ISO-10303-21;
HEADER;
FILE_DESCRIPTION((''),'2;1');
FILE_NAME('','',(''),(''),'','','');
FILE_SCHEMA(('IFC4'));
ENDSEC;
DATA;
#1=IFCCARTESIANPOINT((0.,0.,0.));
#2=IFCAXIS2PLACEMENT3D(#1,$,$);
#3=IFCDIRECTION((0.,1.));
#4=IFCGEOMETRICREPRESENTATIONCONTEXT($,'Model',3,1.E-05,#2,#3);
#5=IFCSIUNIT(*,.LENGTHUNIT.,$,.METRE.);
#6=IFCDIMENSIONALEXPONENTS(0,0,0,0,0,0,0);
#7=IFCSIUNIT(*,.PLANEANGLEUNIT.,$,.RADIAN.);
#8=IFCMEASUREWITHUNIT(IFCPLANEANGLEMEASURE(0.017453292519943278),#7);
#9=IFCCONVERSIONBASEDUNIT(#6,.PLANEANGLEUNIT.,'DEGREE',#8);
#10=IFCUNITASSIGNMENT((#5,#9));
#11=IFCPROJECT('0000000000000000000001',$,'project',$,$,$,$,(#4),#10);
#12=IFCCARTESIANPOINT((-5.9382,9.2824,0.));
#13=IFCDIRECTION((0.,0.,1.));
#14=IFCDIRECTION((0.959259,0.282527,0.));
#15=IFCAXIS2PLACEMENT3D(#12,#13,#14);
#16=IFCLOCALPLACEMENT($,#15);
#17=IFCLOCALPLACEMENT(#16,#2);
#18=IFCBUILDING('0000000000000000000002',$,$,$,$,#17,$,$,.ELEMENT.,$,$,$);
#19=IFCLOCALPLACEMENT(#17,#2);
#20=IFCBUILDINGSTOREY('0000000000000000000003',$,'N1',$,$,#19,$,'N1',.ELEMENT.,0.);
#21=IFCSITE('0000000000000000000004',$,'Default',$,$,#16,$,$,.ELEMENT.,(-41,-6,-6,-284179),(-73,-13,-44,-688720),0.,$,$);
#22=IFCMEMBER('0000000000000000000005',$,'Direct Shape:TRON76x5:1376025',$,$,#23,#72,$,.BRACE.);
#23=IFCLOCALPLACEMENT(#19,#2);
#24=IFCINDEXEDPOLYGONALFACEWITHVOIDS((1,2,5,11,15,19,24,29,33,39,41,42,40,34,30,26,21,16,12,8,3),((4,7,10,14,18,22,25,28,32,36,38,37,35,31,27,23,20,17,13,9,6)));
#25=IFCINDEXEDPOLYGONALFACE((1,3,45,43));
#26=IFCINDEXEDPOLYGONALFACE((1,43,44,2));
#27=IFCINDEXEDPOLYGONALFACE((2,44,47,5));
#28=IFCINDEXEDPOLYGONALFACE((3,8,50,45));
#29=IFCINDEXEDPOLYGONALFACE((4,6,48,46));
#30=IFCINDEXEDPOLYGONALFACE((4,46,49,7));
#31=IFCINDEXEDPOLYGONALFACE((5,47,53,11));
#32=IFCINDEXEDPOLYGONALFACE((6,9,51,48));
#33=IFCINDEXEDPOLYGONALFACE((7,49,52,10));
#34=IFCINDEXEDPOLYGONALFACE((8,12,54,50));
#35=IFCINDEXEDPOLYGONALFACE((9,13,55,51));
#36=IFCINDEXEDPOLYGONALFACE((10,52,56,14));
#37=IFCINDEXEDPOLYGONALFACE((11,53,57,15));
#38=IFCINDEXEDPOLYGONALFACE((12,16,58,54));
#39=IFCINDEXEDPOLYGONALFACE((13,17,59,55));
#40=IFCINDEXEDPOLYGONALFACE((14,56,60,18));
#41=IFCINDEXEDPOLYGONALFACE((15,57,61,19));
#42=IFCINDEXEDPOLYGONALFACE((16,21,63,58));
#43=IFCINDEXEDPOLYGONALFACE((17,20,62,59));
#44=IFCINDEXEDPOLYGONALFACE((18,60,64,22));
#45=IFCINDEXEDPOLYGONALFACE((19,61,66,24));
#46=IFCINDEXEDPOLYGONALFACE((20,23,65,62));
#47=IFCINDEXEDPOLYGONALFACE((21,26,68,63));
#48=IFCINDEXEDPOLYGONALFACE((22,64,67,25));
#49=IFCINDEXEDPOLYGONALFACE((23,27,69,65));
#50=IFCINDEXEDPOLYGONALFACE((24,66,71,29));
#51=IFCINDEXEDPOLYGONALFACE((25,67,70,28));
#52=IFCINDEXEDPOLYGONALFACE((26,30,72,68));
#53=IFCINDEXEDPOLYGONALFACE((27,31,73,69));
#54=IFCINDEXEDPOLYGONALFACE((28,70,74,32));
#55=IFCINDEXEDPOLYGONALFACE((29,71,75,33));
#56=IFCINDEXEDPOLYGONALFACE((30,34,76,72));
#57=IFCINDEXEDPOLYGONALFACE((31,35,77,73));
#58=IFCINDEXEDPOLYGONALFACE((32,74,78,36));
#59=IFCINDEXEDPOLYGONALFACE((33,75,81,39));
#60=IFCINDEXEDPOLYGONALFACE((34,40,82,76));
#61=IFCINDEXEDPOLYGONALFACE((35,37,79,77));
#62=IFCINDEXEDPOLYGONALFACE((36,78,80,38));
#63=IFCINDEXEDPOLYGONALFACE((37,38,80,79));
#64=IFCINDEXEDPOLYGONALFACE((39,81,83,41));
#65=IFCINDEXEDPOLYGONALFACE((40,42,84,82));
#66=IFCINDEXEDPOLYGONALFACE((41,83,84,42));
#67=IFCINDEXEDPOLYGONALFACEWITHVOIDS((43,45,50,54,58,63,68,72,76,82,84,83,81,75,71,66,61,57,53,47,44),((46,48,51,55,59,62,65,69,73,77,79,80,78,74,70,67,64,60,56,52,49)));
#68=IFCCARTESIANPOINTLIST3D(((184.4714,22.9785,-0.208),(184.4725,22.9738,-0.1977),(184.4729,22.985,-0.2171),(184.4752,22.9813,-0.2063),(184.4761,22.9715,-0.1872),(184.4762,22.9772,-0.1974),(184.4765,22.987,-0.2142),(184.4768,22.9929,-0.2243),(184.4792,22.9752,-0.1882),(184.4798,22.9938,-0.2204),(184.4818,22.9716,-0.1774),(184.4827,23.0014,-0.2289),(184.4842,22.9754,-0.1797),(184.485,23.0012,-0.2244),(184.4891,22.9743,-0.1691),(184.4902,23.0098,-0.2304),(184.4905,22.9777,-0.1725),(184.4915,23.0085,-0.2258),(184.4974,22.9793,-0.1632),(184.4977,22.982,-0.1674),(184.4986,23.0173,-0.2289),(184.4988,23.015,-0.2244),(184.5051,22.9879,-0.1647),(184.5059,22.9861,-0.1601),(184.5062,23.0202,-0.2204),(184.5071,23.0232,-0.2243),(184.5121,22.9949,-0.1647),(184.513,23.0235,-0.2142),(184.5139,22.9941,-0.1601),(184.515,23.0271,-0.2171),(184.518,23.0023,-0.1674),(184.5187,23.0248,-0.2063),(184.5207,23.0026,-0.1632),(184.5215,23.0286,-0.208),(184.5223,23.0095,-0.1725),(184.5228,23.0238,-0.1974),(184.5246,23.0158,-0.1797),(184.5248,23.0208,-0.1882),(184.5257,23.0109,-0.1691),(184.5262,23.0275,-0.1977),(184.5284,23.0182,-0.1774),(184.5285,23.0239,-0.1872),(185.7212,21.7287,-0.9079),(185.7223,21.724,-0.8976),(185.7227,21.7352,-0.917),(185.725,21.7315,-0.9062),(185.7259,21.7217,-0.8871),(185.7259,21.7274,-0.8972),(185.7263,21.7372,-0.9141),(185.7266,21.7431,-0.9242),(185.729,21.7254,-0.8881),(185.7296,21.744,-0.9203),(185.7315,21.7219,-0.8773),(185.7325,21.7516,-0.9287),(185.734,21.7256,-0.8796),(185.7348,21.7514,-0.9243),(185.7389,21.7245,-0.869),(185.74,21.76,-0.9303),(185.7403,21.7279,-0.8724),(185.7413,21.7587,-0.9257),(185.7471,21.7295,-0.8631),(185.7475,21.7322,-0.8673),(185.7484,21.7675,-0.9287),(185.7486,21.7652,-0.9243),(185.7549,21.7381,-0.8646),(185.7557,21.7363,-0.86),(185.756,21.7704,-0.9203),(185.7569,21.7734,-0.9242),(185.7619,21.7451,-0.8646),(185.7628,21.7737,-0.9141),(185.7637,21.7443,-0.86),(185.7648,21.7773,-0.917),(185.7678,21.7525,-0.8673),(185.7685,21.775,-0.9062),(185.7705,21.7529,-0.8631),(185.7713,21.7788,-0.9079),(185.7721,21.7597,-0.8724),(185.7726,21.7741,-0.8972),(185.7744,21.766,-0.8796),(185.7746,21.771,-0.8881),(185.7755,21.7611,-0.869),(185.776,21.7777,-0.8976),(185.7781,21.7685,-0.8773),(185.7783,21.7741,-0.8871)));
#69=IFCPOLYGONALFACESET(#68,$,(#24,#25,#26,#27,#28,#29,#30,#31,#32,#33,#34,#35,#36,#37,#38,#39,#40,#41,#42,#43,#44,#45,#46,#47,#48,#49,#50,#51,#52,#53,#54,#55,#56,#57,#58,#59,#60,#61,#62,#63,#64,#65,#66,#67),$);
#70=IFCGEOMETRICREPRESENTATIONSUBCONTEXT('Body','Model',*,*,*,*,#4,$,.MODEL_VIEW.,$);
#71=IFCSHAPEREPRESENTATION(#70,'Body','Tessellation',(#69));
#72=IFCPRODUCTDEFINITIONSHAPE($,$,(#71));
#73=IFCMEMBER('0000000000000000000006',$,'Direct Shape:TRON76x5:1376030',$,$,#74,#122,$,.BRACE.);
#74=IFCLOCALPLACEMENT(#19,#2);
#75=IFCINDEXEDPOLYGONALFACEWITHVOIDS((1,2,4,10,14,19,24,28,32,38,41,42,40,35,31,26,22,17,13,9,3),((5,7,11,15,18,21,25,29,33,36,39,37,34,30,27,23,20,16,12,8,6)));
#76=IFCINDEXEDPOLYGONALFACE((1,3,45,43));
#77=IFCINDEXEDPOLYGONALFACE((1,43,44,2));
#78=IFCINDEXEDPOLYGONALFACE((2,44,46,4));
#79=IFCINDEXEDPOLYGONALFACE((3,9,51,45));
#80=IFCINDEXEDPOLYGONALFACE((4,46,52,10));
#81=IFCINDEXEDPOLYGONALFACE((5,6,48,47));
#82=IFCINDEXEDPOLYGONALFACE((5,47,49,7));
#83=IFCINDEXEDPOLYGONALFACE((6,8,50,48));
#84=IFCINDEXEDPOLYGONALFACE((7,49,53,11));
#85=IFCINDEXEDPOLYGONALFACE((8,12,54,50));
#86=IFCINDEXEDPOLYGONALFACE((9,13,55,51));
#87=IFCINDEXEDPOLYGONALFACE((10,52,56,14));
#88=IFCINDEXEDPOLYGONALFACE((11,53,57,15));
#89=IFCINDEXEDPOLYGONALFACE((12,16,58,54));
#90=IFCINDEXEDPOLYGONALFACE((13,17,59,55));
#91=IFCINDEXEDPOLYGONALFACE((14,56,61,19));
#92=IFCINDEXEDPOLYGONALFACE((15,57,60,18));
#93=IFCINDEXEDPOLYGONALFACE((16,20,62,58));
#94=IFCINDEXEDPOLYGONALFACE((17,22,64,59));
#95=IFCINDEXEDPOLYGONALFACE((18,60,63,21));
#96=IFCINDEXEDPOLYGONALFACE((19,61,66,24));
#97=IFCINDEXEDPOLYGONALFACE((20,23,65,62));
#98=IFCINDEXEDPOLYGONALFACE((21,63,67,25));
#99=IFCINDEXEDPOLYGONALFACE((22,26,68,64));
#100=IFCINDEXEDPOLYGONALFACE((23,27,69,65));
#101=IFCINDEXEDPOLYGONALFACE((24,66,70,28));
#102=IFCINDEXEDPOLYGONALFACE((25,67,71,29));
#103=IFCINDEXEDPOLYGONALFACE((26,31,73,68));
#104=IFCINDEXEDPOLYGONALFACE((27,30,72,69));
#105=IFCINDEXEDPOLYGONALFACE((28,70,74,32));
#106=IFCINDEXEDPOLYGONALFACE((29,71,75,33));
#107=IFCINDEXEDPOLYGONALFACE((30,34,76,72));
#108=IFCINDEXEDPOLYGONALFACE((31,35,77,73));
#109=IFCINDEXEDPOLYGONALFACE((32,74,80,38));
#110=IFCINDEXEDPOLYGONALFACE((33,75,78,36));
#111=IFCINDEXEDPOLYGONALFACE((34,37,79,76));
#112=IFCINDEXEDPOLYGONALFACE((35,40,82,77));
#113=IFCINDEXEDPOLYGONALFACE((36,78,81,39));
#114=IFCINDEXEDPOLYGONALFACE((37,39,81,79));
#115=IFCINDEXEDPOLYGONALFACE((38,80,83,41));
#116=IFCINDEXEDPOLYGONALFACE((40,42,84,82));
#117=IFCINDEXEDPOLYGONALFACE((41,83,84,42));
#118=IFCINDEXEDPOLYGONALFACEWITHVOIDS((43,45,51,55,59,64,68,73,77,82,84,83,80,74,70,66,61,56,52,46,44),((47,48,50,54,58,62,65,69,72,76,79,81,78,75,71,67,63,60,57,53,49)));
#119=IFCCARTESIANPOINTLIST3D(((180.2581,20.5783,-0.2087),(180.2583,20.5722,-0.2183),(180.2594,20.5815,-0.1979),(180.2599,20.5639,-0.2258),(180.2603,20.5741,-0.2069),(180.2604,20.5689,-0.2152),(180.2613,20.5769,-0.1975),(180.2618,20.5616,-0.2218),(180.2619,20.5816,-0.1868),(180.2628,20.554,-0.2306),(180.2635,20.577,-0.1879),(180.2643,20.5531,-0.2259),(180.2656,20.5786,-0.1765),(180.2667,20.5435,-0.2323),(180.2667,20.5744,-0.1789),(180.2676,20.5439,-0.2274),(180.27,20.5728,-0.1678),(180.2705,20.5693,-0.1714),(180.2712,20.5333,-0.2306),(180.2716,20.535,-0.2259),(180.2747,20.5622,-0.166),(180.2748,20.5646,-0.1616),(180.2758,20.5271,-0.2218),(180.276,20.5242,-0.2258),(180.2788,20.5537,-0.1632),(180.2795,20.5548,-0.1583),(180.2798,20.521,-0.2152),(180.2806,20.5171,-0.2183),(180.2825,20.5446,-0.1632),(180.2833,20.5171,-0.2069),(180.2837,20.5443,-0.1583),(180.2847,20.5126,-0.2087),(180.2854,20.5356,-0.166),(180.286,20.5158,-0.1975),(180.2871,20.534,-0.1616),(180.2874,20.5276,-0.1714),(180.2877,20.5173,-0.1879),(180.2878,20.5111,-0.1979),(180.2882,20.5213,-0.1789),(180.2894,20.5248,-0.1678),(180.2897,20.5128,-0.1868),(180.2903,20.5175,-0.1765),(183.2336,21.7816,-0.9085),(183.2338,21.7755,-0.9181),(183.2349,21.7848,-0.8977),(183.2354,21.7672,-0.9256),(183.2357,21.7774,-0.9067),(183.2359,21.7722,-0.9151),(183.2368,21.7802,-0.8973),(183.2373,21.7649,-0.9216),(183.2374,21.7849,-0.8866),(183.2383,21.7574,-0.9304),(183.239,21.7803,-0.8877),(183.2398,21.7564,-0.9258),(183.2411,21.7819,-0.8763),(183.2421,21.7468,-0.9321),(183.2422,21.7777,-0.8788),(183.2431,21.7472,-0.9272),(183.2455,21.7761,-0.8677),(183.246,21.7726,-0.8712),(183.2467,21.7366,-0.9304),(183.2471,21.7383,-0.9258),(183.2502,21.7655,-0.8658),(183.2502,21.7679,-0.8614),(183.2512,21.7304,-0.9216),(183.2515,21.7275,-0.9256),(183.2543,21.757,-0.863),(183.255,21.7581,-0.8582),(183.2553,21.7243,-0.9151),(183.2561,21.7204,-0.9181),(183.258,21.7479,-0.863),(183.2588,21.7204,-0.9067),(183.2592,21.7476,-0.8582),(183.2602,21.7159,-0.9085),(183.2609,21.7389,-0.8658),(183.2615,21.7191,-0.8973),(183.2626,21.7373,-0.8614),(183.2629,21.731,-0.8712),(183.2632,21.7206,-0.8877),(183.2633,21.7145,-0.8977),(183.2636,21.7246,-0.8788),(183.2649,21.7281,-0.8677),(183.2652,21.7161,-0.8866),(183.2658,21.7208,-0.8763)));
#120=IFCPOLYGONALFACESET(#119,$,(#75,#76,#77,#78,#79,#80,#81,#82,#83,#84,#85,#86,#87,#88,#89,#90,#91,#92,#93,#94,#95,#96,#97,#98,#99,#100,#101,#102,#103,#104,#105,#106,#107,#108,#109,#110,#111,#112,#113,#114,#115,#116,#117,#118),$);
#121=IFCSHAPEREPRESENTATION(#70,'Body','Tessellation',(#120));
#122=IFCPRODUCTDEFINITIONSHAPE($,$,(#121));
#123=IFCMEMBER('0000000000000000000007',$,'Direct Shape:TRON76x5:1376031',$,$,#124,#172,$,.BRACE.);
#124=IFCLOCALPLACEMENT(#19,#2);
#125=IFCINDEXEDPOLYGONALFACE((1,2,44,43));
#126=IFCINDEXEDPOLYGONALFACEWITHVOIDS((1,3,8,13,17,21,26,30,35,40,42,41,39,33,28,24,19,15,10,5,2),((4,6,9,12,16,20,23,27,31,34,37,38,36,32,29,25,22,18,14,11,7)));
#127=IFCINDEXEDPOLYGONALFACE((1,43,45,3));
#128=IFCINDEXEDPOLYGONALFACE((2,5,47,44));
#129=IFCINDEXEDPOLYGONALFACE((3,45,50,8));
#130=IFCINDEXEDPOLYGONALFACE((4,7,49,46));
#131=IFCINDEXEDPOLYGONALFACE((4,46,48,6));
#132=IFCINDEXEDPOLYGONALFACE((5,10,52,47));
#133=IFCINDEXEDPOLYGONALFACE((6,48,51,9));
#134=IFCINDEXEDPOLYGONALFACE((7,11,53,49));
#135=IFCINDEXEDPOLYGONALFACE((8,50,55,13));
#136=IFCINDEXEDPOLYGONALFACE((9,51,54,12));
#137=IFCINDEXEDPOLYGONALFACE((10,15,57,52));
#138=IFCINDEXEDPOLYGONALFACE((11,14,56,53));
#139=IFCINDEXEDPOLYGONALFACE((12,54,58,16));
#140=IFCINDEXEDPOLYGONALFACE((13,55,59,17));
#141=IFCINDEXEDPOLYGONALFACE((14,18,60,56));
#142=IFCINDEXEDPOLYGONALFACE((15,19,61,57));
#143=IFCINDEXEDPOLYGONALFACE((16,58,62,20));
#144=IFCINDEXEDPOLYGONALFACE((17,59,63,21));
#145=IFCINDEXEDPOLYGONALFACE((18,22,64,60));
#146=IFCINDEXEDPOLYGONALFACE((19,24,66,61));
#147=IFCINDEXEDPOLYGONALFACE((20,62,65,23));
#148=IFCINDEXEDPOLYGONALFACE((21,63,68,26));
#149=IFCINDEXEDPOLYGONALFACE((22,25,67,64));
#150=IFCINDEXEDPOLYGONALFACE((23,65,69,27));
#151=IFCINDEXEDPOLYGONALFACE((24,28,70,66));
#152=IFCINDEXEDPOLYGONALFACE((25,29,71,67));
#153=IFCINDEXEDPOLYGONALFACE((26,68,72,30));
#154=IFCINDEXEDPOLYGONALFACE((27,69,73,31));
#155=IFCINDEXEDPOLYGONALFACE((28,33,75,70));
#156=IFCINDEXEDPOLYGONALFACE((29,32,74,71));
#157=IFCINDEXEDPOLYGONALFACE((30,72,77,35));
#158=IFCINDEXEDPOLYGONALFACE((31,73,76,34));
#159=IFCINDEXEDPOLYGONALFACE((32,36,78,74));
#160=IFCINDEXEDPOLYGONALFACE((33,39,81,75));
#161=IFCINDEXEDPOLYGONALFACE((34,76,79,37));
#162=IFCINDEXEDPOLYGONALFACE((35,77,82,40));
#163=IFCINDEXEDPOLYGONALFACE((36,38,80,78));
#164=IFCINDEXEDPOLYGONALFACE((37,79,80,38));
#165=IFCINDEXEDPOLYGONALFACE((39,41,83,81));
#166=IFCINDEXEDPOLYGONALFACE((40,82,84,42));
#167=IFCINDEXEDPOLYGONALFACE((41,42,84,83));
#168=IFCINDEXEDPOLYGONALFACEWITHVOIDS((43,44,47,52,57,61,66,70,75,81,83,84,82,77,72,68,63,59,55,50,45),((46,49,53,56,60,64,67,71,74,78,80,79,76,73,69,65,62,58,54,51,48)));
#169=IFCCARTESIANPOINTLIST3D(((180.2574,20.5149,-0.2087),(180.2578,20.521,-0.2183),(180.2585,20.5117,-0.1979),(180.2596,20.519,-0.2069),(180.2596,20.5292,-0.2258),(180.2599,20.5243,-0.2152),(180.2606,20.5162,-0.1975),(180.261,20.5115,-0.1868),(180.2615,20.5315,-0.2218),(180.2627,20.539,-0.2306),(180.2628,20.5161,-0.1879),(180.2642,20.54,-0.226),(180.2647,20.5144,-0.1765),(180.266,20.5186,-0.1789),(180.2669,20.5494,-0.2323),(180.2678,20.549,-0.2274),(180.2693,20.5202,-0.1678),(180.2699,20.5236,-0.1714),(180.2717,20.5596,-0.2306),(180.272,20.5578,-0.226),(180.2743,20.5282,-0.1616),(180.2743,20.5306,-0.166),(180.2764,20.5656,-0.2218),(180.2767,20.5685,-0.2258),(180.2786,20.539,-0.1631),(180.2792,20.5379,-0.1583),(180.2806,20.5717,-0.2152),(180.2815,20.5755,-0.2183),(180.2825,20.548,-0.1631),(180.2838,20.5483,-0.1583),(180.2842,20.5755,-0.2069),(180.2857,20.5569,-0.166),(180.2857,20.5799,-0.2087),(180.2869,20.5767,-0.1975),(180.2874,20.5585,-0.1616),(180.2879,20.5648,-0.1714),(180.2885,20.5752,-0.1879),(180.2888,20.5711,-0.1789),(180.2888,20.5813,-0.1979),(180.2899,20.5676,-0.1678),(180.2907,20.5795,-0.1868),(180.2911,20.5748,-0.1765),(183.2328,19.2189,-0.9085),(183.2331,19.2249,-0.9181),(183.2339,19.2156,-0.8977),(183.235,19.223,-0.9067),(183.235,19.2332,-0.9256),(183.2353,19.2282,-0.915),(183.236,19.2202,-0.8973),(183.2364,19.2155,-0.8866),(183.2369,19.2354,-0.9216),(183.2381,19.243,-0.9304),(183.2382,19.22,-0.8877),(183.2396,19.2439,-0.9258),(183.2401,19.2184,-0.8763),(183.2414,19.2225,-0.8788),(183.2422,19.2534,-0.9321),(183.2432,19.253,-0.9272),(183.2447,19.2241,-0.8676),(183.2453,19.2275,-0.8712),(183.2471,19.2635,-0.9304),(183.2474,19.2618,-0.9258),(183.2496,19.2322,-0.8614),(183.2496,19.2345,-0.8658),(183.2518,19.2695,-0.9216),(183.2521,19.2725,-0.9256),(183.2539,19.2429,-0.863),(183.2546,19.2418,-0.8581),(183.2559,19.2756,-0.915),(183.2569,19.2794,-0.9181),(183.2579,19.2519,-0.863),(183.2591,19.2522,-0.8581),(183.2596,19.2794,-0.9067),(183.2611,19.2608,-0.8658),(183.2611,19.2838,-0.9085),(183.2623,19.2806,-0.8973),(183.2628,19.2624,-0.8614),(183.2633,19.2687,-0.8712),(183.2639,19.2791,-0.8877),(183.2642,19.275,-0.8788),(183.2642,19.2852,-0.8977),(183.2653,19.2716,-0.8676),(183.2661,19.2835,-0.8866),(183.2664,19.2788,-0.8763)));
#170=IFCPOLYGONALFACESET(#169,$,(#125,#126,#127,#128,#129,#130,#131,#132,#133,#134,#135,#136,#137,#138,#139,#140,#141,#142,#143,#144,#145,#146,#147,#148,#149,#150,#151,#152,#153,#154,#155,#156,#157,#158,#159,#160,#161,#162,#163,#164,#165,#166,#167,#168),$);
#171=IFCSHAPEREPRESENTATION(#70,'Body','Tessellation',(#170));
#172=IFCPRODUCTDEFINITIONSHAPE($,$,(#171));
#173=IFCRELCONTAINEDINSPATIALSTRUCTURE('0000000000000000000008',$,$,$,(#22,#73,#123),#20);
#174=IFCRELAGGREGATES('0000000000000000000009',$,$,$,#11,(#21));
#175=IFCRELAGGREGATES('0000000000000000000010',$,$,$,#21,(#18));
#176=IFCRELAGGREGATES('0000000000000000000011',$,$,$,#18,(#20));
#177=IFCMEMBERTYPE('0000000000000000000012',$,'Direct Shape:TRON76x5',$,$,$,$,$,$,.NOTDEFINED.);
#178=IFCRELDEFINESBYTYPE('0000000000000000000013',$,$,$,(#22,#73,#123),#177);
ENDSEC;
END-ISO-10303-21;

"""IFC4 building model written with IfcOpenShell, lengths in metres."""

from ifc_helpers import new_model, entity, si_unit, converted_unit, direction, frame, frame_2d, origin, origin_2d_with_axis, place, context, subcontext, project, spatial, hollow_circle, extrude, type_object, element, save


model = new_model("IFC4")

# Units and contexts
model_context = context("Model", 3, precision=1e-05, world=origin(), true_north=direction((0.0, 1.0)))
body_context = subcontext(model_context, "Body", "Model", "MODEL_VIEW")
ifc_project = project(units=[si_unit("LENGTHUNIT", "METRE"), converted_unit("PLANEANGLEUNIT", "DEGREE", entity("IfcPlaneAngleMeasure", 0.017453292519943278), si_unit("PLANEANGLEUNIT", "RADIAN"), dimensions=[0, 0, 0, 0, 0, 0, 0])], contexts=[model_context])

# Site, building, storey
site_placement = place(None, frame((-5.9382, 9.2824, 0.0), z_axis=(0.0, 0.0, 1.0), x_axis=(0.959259, 0.282527, 0.0)))
site = spatial("IfcSite", under=ifc_project, at=site_placement, Name="Default", CompositionType="ELEMENT", RefLatitude=(-41, -6, -6, -284179), RefLongitude=(-73, -13, -44, -688720), RefElevation=0.0)
building_placement = place(site_placement, origin())
building = spatial("IfcBuilding", under=site, at=building_placement, CompositionType="ELEMENT")
storey_placement = place(building_placement, origin())
storey = spatial("IfcBuildingStorey", under=building, at=storey_placement, Name="N1", LongName="N1", CompositionType="ELEMENT", Elevation=0.0)

# Members
member_type_1 = type_object("IfcMemberType", Name="Direct Shape:TRON76x5", PredefinedType="NOTDEFINED")
member_1_placement = place(storey_placement, origin())
element("IfcMember", 1, at=member_1_placement, inside=storey, type_object=member_type_1, Name="Direct Shape:TRON76x5:1376025", PredefinedType="BRACE", context=body_context, shape_type="SweptSolid", body=[
    extrude(hollow_circle(Radius=0.0381, WallThickness=0.005, at=origin_2d_with_axis()), frame((185.7499, 21.7501, -0.8949), z_axis=(-0.65744, 0.65744, 0.368166), x_axis=(-0.260333, 0.260333, -0.92976)), (0.0, 0.0, 1.0), 1.901),
])
member_2_placement = place(storey_placement, origin())
element("IfcMember", 2, at=member_2_placement, inside=storey, type_object=member_type_1, Name="Direct Shape:TRON76x5:1376030", PredefinedType="BRACE", context=body_context, shape_type="SweptSolid", body=[
    extrude(hollow_circle(Radius=0.0381, WallThickness=0.005, at=frame_2d((0.0, 0.0), x_axis=(1.0, 0.0))), frame((180.2742, 20.5466, -0.1951), z_axis=(0.905779, 0.366304, -0.21304), x_axis=(-0.197501, -0.079871, -0.977043)), (0.0, 0.0, 1.0), 3.285),
])
member_3_placement = place(storey_placement, origin())
element("IfcMember", 3, at=member_3_placement, inside=storey, type_object=member_type_1, Name="Direct Shape:TRON76x5:1376031", PredefinedType="BRACE", context=body_context, shape_type="SweptSolid", body=[
    extrude(hollow_circle(Radius=0.0381, WallThickness=0.005, at=frame_2d((0.0, 0.0), x_axis=(1.0, 0.0))), frame((180.2742, 20.5462, -0.1951), z_axis=(0.896198, -0.390381, -0.210787), x_axis=(-0.193249, 0.084178, -0.977532)), (0.0, 0.0, 1.0), 3.32),
])

save(model, "model.ifc")
